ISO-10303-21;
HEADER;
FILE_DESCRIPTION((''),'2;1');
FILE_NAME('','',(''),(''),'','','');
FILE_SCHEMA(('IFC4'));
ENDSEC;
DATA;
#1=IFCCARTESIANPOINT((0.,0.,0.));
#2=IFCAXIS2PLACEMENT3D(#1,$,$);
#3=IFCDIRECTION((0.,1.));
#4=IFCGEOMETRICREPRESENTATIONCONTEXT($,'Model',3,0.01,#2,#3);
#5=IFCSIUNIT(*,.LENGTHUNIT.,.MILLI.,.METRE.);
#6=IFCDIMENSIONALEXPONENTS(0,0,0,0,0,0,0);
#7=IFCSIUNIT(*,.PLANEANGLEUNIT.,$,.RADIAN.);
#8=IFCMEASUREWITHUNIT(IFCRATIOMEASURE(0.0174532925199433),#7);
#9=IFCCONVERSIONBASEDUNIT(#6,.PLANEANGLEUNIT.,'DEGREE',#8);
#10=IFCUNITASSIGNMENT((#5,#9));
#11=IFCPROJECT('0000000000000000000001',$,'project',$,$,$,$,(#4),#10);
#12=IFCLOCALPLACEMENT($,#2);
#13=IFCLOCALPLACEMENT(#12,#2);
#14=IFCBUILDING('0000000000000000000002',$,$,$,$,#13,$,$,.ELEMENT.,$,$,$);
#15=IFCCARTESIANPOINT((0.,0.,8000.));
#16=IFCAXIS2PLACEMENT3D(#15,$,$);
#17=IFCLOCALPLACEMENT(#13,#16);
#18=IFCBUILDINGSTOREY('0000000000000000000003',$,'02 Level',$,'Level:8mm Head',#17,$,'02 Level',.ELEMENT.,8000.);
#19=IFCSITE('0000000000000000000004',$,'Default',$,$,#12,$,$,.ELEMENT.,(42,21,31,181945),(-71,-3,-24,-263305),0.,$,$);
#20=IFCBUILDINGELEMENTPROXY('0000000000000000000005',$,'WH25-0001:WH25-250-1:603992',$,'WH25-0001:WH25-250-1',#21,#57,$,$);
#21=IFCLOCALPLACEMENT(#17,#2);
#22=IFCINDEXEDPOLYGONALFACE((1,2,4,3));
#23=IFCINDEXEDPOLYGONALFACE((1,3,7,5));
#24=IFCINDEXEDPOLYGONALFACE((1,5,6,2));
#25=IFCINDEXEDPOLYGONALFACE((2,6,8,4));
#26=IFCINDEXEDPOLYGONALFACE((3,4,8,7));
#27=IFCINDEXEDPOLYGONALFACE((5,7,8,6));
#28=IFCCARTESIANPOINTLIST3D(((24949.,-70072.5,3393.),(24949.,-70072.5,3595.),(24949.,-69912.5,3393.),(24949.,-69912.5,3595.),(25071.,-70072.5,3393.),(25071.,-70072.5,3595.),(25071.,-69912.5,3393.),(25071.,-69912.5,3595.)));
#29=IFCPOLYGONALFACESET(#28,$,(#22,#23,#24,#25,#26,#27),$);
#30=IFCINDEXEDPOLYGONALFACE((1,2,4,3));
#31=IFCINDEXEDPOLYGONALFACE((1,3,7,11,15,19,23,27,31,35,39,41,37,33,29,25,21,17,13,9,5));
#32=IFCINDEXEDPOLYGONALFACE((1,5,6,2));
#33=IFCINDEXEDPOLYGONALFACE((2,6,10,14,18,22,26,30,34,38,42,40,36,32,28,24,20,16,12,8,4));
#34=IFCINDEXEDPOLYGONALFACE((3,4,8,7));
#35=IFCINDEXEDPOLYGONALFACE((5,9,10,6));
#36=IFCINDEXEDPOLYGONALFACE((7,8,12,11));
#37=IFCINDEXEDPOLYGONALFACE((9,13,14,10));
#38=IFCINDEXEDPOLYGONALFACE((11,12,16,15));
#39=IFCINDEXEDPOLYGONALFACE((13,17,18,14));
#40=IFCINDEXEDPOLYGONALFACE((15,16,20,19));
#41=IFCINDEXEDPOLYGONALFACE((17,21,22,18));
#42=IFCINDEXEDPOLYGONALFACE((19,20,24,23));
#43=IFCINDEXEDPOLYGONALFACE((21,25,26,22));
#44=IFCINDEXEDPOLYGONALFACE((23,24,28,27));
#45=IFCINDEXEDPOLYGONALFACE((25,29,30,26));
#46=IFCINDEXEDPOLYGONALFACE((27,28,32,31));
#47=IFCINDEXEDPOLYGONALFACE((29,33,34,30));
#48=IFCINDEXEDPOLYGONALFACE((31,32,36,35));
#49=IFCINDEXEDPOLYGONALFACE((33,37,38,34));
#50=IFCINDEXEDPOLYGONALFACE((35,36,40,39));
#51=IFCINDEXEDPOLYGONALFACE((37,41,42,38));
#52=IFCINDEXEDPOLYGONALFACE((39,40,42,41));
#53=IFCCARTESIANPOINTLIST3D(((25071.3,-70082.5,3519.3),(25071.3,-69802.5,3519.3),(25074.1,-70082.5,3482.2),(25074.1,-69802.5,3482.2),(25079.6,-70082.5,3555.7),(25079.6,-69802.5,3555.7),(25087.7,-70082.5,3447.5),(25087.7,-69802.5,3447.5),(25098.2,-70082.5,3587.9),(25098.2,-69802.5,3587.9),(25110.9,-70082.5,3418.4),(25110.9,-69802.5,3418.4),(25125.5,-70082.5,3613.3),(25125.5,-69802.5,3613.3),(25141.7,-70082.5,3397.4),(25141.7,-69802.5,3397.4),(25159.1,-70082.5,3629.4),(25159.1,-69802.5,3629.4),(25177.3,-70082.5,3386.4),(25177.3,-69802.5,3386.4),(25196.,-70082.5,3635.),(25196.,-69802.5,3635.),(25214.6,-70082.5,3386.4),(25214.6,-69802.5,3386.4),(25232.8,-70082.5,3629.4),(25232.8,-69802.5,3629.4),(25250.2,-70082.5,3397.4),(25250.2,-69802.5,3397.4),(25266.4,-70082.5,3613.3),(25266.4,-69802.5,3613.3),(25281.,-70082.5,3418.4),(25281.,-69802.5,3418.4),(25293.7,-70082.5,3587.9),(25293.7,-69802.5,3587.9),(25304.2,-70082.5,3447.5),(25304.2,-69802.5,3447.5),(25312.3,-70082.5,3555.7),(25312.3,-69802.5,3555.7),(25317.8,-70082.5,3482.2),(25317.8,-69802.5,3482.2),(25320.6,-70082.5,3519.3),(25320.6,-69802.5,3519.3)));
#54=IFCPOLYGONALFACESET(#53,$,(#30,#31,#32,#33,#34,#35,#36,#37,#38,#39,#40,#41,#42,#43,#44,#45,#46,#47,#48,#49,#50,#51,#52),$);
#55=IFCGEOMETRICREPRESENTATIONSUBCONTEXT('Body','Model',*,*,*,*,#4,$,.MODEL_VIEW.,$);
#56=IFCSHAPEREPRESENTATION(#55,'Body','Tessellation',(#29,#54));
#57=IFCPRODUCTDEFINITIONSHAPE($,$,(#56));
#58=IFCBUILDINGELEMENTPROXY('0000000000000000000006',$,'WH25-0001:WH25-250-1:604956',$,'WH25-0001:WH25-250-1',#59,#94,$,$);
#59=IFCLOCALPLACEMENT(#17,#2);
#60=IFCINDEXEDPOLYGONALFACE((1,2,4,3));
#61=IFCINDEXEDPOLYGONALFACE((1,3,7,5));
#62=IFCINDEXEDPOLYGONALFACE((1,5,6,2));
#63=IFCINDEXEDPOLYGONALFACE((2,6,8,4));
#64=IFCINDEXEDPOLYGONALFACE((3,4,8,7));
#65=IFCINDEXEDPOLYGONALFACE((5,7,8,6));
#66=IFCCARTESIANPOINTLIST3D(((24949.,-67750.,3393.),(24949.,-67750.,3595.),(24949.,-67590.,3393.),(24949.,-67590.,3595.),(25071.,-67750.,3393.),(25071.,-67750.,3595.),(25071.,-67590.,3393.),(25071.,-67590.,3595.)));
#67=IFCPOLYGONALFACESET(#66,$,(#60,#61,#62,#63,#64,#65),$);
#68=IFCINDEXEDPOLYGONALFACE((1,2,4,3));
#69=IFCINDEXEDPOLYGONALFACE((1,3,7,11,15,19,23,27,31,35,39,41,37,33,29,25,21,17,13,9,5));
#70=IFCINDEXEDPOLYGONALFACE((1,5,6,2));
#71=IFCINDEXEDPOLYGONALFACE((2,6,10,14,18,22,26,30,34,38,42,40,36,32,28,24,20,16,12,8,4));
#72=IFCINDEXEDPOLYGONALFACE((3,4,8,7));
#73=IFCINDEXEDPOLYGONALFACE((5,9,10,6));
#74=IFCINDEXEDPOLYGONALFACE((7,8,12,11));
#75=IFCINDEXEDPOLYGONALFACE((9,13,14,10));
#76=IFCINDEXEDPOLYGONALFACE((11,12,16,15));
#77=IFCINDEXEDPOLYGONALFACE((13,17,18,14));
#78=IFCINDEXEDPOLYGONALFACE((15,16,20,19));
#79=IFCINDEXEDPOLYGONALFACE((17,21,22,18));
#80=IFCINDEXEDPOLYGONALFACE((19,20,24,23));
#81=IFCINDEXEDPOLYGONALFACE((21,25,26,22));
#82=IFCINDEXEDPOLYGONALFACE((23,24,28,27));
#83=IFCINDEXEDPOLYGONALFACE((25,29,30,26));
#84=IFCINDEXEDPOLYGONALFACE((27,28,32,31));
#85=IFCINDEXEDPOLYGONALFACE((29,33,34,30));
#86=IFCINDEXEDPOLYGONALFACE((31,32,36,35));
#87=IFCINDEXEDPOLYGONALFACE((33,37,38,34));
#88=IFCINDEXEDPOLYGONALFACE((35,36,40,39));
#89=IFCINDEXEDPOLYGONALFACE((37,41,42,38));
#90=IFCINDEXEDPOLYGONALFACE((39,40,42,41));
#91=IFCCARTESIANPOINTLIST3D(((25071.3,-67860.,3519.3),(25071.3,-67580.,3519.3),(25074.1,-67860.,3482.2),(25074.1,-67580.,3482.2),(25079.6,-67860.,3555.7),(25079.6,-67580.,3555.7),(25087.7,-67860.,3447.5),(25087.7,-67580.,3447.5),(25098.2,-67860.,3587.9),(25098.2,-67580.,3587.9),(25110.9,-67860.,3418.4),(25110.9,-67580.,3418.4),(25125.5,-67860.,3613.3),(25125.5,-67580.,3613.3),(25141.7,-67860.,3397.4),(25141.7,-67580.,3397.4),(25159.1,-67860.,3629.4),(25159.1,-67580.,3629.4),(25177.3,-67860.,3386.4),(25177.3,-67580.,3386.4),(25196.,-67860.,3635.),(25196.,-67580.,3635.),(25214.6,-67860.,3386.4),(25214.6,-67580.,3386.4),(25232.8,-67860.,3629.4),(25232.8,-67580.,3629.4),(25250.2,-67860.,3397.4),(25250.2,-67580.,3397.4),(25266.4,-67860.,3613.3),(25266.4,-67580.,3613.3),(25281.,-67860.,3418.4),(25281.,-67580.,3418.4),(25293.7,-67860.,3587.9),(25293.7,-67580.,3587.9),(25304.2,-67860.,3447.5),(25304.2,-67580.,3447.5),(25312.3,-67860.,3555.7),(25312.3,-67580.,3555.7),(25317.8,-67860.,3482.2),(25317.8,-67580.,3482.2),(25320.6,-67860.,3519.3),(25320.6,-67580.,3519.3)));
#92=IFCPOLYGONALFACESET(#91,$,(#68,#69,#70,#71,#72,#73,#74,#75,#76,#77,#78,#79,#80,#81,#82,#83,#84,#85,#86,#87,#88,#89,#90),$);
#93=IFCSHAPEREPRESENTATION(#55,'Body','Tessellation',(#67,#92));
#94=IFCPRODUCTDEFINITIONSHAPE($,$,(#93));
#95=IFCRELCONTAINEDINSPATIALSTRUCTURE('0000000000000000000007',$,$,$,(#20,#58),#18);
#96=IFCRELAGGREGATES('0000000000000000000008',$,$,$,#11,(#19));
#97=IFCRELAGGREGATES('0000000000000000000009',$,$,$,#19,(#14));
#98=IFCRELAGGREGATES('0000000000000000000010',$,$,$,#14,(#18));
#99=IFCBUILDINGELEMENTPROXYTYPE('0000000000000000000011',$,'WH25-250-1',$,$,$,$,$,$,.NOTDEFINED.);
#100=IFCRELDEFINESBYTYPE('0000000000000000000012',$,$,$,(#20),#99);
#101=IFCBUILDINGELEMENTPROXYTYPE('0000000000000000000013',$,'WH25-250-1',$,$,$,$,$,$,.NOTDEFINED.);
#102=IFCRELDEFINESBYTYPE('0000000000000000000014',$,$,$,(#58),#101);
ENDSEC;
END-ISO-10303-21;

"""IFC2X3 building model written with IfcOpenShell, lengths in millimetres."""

from ifc_helpers import new_model, entity, si_unit, converted_unit, direction, frame, frame_2d, origin, origin_2d_with_axis, place, context, subcontext, project, spatial, rectangle, circle, extrude, source, transform, mapped, type_object, type_shapes, element, save


model = new_model("IFC2X3")

# Units and contexts
model_context = context("Model", 3, precision=0.01, world=origin(), true_north=direction((0.0, 1.0)))
body_context = subcontext(model_context, "Body", "Model", "MODEL_VIEW")
ifc_project = project(units=[si_unit("LENGTHUNIT", "METRE", prefix="MILLI"), converted_unit("PLANEANGLEUNIT", "DEGREE", entity("IfcRatioMeasure", 0.0174532925199433), si_unit("PLANEANGLEUNIT", "RADIAN"), dimensions=[0, 0, 0, 0, 0, 0, 0])], contexts=[model_context])

# Site, building, storey
site_placement = place(None, origin())
site = spatial("IfcSite", under=ifc_project, at=site_placement, Name="Default", CompositionType="ELEMENT", RefLatitude=(42, 21, 31, 181945), RefLongitude=(-71, -3, -24, -263305), RefElevation=0.0)
building_placement = place(site_placement, origin())
building = spatial("IfcBuilding", under=site, at=building_placement, CompositionType="ELEMENT")
storey_placement = place(building_placement, frame((0.0, 0.0, 8000.0)))
storey = spatial("IfcBuildingStorey", under=building, at=storey_placement, Name="02 Level", ObjectType="Level:8mm Head", LongName="02 Level", CompositionType="ELEMENT", Elevation=8000.0)

# Building element proxies
building_element_proxy_type_1 = type_object("IfcBuildingElementProxyType", Name="WH25-250-1", PredefinedType="NOTDEFINED")
shared_shape_1 = source(origin(), body_context, "Body", "SweptSolid", [
    extrude(rectangle(XDim=202.0, YDim=160.0, at=origin_2d_with_axis()), frame((50.0, -16.0, 125.0), z_axis=(0.0, 0.0, 1.0), x_axis=(0.0, -1.0, 0.0)), (0.0, 0.0, 1.0), 122.0),
    extrude(circle(Radius=125.0, at=frame_2d((0.0, 0.0), x_axis=(1.0, 0.0))), frame((-140.0, 0.0, 0.0), z_axis=(1.0, 0.0, 0.0), x_axis=(0.0, 1.0, 0.0)), (0.0, 0.0, 1.0), 280.0),
])
type_shapes(building_element_proxy_type_1, [shared_shape_1])
proxy_1_placement = place(storey_placement, frame((25196.0, -69942.5, 3510.0), z_axis=(-1.0, 0.0, 0.0), x_axis=(0.0, -1.0, 0.0)))
element("IfcBuildingElementProxy", 1, at=proxy_1_placement, inside=storey, type_object=building_element_proxy_type_1, Name="WH25-0001:WH25-250-1:603992", ObjectType="WH25-0001:WH25-250-1", context=body_context, shape_type="MappedRepresentation", body=[
    mapped(shared_shape_1, transform((0.0, 0.0, 0.0), scale=1.0)),
])
building_element_proxy_type_2 = type_object("IfcBuildingElementProxyType", Name="WH25-250-1", PredefinedType="NOTDEFINED")
shared_shape_2 = source(origin(), body_context, "Body", "SweptSolid", [
    extrude(rectangle(XDim=160.0, YDim=202.0, at=origin_2d_with_axis()), frame((50.0, 16.0, 125.0)), (0.0, 0.0, 1.0), 122.0),
    extrude(circle(Radius=125.0, at=frame_2d((0.0, 0.0), x_axis=(1.0, 0.0))), frame((-140.0, 0.0, 0.0), z_axis=(1.0, 0.0, 0.0), x_axis=(0.0, -1.0, 0.0)), (0.0, 0.0, 1.0), 280.0),
])
type_shapes(building_element_proxy_type_2, [shared_shape_2])
proxy_2_placement = place(storey_placement, frame((25196.0, -67720.0, 3510.0), z_axis=(-1.0, 0.0, 0.0), x_axis=(0.0, 1.0, 0.0)))
element("IfcBuildingElementProxy", 2, at=proxy_2_placement, inside=storey, type_object=building_element_proxy_type_2, Name="WH25-0001:WH25-250-1:604956", ObjectType="WH25-0001:WH25-250-1", context=body_context, shape_type="MappedRepresentation", body=[
    mapped(shared_shape_2, transform((0.0, 0.0, 0.0), scale=1.0)),
])

save(model, "model.ifc")
